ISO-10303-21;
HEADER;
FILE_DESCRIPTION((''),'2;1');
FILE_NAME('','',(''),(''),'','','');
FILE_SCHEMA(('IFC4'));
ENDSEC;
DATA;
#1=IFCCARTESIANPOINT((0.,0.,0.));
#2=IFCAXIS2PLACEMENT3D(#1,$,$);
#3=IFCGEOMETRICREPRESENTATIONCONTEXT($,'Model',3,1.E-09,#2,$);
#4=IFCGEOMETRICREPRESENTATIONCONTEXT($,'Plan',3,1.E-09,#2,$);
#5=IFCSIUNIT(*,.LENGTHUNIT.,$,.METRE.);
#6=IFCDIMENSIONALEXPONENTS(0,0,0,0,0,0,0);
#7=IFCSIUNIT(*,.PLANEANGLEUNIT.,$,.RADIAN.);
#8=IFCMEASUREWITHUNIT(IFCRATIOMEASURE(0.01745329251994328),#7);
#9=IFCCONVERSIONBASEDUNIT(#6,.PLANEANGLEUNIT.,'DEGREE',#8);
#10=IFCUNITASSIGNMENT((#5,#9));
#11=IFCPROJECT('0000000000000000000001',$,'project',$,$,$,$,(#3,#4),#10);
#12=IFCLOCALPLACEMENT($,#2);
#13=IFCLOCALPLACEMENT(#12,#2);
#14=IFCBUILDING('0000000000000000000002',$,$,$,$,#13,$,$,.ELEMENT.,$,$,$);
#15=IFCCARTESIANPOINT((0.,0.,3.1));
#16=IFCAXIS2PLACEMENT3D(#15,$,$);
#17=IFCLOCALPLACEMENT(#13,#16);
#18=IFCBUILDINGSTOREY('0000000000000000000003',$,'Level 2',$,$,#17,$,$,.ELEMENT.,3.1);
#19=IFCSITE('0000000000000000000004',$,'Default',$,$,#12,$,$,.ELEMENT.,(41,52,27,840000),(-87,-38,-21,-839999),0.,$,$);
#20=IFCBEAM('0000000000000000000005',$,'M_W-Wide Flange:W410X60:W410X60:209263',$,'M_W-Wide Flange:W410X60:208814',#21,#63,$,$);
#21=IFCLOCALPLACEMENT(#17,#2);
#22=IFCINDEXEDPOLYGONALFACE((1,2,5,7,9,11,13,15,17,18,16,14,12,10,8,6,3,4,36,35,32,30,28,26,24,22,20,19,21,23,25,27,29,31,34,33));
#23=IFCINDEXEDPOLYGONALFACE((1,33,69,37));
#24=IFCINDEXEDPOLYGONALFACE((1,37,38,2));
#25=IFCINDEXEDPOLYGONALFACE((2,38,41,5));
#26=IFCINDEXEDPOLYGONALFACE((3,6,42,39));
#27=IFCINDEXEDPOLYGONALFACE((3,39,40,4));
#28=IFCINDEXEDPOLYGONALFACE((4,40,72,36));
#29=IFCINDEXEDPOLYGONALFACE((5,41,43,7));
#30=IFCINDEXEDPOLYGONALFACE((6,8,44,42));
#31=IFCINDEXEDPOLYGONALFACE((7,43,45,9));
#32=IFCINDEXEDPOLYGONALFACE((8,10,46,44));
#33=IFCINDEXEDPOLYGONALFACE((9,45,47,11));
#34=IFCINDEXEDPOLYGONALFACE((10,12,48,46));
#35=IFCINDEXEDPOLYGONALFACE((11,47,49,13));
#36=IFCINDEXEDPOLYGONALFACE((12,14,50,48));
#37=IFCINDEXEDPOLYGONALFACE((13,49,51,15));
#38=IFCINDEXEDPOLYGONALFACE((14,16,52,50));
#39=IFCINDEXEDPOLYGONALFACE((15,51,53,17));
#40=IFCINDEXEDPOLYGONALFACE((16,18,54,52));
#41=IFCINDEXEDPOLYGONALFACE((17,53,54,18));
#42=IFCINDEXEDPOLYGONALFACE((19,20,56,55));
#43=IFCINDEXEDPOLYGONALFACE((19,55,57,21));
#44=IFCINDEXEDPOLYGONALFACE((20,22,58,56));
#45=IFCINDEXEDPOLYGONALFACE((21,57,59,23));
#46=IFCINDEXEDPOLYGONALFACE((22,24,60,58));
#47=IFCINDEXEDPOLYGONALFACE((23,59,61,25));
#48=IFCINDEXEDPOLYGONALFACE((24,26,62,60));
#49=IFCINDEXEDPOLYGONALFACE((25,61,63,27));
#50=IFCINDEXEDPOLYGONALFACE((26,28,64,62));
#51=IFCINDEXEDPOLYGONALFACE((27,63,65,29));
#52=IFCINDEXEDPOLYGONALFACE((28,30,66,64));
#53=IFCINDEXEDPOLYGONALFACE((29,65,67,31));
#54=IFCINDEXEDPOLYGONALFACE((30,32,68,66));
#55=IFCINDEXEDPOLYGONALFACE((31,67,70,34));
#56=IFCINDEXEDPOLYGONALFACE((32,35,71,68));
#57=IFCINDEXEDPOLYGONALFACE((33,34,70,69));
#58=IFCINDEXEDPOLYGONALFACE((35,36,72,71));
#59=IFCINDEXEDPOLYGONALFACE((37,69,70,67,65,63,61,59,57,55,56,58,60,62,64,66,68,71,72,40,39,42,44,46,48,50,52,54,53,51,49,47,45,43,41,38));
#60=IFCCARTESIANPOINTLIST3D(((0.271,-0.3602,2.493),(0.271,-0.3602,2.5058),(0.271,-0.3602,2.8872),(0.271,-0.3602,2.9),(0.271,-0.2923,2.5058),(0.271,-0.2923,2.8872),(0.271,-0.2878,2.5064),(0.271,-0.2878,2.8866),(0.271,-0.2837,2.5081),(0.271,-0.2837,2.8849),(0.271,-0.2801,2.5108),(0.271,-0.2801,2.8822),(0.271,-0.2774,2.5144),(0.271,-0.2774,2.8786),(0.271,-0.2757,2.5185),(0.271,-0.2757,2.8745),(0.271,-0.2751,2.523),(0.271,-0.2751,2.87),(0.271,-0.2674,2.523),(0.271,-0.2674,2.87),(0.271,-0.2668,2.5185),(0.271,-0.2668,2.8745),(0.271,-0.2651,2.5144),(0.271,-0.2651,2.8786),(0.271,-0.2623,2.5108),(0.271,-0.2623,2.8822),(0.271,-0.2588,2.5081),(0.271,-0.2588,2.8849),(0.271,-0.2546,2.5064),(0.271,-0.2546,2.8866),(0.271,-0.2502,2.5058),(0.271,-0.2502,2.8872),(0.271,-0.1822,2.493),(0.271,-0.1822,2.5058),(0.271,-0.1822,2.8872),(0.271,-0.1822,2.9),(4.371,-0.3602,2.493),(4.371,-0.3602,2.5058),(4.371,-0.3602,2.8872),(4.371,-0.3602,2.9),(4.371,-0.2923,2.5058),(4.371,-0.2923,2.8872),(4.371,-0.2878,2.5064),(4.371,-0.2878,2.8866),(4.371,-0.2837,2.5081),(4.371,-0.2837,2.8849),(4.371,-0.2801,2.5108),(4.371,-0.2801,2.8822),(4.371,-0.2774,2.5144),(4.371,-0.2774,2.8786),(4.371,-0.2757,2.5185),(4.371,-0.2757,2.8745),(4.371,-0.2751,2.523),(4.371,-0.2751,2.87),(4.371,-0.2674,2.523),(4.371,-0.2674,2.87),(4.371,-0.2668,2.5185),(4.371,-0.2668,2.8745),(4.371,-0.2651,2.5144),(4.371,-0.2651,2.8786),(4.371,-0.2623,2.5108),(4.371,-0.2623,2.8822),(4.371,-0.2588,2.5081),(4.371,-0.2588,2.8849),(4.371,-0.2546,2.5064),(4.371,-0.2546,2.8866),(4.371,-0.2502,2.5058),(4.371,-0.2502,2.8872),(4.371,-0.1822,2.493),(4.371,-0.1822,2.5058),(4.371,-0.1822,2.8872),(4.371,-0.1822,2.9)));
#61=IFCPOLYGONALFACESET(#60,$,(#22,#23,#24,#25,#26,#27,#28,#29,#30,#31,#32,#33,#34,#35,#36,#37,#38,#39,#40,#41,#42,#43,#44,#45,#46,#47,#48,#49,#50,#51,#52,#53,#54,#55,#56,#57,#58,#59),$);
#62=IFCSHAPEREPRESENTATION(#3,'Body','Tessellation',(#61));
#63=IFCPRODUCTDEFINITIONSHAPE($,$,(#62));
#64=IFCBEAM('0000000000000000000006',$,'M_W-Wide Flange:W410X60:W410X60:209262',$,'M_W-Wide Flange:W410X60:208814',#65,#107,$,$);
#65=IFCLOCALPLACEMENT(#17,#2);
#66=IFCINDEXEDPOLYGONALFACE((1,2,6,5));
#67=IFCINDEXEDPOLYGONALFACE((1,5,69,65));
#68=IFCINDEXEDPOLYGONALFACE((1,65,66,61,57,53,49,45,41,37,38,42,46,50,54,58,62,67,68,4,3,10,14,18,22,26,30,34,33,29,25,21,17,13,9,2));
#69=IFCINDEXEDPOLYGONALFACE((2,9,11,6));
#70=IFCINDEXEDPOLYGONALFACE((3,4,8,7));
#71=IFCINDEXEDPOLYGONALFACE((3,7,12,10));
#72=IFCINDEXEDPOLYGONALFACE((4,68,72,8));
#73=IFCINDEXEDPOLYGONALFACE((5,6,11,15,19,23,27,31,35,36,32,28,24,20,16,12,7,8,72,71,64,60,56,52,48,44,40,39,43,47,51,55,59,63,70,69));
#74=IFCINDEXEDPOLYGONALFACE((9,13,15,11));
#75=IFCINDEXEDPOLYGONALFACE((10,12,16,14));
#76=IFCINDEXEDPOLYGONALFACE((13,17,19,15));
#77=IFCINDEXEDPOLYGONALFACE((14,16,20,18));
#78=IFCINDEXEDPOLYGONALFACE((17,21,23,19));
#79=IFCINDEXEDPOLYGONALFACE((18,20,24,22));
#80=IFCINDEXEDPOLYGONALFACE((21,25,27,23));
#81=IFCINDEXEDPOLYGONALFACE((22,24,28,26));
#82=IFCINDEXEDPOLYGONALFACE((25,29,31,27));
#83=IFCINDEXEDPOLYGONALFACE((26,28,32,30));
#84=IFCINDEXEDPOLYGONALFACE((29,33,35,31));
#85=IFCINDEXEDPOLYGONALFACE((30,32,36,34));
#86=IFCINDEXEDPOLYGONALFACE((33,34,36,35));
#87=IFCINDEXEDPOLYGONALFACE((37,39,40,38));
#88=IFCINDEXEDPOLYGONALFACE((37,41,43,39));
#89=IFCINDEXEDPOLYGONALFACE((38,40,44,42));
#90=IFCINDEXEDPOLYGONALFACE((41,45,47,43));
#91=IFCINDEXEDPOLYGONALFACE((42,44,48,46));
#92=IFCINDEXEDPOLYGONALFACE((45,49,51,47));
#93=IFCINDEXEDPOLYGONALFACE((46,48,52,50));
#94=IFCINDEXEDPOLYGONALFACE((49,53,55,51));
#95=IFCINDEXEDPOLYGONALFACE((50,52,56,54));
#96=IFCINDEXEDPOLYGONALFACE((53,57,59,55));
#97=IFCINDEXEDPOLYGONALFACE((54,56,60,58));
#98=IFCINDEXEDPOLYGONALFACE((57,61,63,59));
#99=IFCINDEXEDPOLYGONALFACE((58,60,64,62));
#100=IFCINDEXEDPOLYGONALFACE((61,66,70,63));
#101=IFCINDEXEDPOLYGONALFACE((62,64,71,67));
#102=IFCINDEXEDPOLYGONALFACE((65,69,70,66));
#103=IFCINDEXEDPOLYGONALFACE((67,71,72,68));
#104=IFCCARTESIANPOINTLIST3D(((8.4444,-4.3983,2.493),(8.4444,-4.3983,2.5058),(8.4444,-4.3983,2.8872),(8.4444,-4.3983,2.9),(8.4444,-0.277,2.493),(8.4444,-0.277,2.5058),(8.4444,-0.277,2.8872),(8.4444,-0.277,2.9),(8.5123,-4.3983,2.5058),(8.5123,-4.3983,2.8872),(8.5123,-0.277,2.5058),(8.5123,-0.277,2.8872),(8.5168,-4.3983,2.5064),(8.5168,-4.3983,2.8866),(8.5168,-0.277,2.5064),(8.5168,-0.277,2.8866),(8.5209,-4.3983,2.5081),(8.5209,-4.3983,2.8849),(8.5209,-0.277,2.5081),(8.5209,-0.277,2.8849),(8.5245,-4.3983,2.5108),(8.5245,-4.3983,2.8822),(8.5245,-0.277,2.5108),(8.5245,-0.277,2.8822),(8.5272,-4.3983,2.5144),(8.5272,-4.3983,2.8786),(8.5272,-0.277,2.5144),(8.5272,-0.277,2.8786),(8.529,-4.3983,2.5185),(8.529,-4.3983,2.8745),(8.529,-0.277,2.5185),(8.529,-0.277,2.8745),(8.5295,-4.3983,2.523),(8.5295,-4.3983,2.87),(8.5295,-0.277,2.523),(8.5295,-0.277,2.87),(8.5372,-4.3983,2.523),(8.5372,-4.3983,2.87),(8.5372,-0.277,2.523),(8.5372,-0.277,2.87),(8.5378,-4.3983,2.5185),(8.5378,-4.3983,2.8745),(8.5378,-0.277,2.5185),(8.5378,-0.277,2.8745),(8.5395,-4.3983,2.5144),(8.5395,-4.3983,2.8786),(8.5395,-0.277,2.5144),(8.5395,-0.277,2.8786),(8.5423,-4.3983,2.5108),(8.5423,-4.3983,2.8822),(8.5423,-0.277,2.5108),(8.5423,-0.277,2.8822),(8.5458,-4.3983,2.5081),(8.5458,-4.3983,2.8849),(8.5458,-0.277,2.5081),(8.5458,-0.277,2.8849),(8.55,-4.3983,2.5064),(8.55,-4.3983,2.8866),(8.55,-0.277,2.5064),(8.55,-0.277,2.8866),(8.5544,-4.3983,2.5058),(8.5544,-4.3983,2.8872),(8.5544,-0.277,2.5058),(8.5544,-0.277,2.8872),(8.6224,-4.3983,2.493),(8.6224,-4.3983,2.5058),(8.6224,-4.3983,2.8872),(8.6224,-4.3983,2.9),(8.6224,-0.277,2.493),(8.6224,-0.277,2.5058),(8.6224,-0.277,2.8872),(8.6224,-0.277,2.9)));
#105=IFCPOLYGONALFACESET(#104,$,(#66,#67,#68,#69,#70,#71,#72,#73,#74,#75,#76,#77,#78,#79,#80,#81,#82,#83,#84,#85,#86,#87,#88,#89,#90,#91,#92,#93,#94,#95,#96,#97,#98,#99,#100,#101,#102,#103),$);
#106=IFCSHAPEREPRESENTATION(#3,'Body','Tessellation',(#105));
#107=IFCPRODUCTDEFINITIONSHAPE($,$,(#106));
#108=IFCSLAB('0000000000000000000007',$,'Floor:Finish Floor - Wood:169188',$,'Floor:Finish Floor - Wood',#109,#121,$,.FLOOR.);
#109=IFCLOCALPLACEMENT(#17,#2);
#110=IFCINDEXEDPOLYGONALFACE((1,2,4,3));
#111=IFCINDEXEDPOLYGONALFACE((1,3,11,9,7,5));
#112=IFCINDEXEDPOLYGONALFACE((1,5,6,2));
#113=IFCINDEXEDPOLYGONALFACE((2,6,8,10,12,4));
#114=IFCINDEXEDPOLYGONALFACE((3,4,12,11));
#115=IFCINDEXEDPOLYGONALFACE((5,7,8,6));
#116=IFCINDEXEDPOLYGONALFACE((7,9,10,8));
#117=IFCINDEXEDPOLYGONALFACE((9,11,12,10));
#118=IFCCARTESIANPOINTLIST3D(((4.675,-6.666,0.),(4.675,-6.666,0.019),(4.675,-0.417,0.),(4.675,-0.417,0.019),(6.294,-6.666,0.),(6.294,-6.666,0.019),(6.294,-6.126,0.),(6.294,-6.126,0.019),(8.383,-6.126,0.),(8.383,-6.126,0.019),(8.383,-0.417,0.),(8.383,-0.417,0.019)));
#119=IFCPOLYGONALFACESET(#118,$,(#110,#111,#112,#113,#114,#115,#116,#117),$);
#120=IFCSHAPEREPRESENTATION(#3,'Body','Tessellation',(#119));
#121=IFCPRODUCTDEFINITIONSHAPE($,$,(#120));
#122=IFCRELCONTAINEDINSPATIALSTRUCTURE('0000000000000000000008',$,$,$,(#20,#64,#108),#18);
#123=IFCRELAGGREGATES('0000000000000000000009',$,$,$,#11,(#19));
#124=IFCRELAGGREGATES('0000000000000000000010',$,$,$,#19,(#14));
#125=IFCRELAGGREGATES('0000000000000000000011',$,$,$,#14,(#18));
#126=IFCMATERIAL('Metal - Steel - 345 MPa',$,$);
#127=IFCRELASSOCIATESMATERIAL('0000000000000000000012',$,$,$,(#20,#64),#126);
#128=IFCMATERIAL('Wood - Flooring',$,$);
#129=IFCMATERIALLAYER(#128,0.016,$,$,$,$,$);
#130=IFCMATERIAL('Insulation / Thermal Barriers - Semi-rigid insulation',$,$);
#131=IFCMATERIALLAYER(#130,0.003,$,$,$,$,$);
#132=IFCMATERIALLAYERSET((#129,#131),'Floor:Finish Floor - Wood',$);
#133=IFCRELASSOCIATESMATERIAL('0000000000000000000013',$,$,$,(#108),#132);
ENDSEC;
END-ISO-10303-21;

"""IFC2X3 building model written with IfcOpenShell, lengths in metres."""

from ifc_helpers import new_model, entity, si_unit, converted_unit, frame, frame_2d, origin, place, context, project, spatial, polyline, circle_curve, parameter, trimmed, segment, composite_curve, outline, extrude, material, layer, layer_set, layer_usage, element, save


model = new_model("IFC2X3")

# Units and contexts
model_context = context("Model", 3, precision=1e-09, world=origin())
plan_context = context("Plan", 3, precision=1e-09, world=origin())
ifc_project = project(units=[si_unit("LENGTHUNIT", "METRE"), converted_unit("PLANEANGLEUNIT", "DEGREE", entity("IfcRatioMeasure", 0.01745329251994328), si_unit("PLANEANGLEUNIT", "RADIAN"), dimensions=[0, 0, 0, 0, 0, 0, 0])], contexts=[model_context, plan_context])

# Site, building, storey
site_placement = place(None, origin())
site = spatial("IfcSite", under=ifc_project, at=site_placement, Name="Default", CompositionType="ELEMENT", RefLatitude=(41, 52, 27, 840000), RefLongitude=(-87, -38, -21, -839999), RefElevation=0.0)
building_placement = place(site_placement, origin())
building = spatial("IfcBuilding", under=site, at=building_placement, CompositionType="ELEMENT")
storey_placement = place(building_placement, frame((0.0, 0.0, 3.1)))
storey = spatial("IfcBuildingStorey", under=building, at=storey_placement, Name="Level 2", CompositionType="ELEMENT", Elevation=3.1)

# Beams
ifc_material_1 = material(Name="Metal - Steel - 345 MPa")
beam_1_placement = place(storey_placement, frame((4.371, -0.2712, 2.9), z_axis=(0.0, 0.0, 1.0), x_axis=(0.0, 1.0, 0.0)))
element("IfcBeam", 1, at=beam_1_placement, inside=storey, material=ifc_material_1, Name="M_W-Wide Flange:W410X60:W410X60:209263", ObjectType="M_W-Wide Flange:W410X60:208814", context=model_context, shape_type="SweptSolid", body=[
    extrude(outline(composite_curve([segment(polyline([(0.1907, -0.089), (0.2035, -0.089)]), True, "CONTINUOUS"), segment(polyline([(0.2035, -0.089), (0.2035, 0.089)]), True, "CONTINUOUS"), segment(polyline([(0.2035, 0.089), (0.1907, 0.089)]), True, "CONTINUOUS"), segment(polyline([(0.1907, 0.089), (0.1907, 0.0211)]), True, "CONTINUOUS"), segment(trimmed(circle_curve(frame_2d((0.1735, 0.0211), x_axis=(1.0, 0.0)), 0.0172), [parameter(270.0)], [parameter(360.0)], True, "PARAMETER"), False, "CONTINUOUS"), segment(polyline([(0.1735, 0.0039), (-0.1735, 0.0039)]), True, "CONTINUOUS"), segment(trimmed(circle_curve(frame_2d((-0.1735, 0.0211), x_axis=(0.0, -1.0)), 0.0172), [parameter(270.0)], [parameter(360.0)], True, "PARAMETER"), False, "CONTINUOUS"), segment(polyline([(-0.1907, 0.0211), (-0.1907, 0.089)]), True, "CONTINUOUS"), segment(polyline([(-0.1907, 0.089), (-0.2035, 0.089)]), True, "CONTINUOUS"), segment(polyline([(-0.2035, 0.089), (-0.2035, -0.089)]), True, "CONTINUOUS"), segment(polyline([(-0.2035, -0.089), (-0.1907, -0.089)]), True, "CONTINUOUS"), segment(polyline([(-0.1907, -0.089), (-0.1907, -0.0211)]), True, "CONTINUOUS"), segment(trimmed(circle_curve(frame_2d((-0.1735, -0.0211), x_axis=(-1.0, 0.0)), 0.0172), [parameter(270.0)], [parameter(0.0)], True, "PARAMETER"), False, "CONTINUOUS"), segment(polyline([(-0.1735, -0.0039), (0.1735, -0.0039)]), True, "CONTINUOUS"), segment(trimmed(circle_curve(frame_2d((0.1735, -0.0211), x_axis=(0.0, 1.0)), 0.0172), [parameter(270.0)], [parameter(0.0)], True, "PARAMETER"), False, "CONTINUOUS"), segment(polyline([(0.1907, -0.0211), (0.1907, -0.089)]), True, "CONTINUOUS")], self_intersect=False)), frame((0.0, 4.1, -0.2035), z_axis=(0.0, -1.0, 0.0), x_axis=(0.0, 0.0, -1.0)), (0.0, 0.0, 1.0), 4.1),
])
beam_2_placement = place(storey_placement, frame((8.5334, -4.3983, 2.9)))
element("IfcBeam", 2, at=beam_2_placement, inside=storey, material=ifc_material_1, Name="M_W-Wide Flange:W410X60:W410X60:209262", ObjectType="M_W-Wide Flange:W410X60:208814", context=model_context, shape_type="SweptSolid", body=[
    extrude(outline(composite_curve([segment(polyline([(-0.089, -0.1907), (-0.089, -0.2035)]), True, "CONTINUOUS"), segment(polyline([(-0.089, -0.2035), (0.089, -0.2035)]), True, "CONTINUOUS"), segment(polyline([(0.089, -0.2035), (0.089, -0.1907)]), True, "CONTINUOUS"), segment(polyline([(0.089, -0.1907), (0.021, -0.1907)]), True, "CONTINUOUS"), segment(trimmed(circle_curve(frame_2d((0.021, -0.1735), x_axis=(0.0, -1.0)), 0.0172), [parameter(270.0)], [parameter(360.0)], True, "PARAMETER"), False, "CONTINUOUS"), segment(polyline([(0.0038, -0.1735), (0.0038, 0.1735)]), True, "CONTINUOUS"), segment(trimmed(circle_curve(frame_2d((0.021, 0.1735), x_axis=(-1.0, 0.0)), 0.0172), [parameter(270.0)], [parameter(360.0)], True, "PARAMETER"), False, "CONTINUOUS"), segment(polyline([(0.021, 0.1907), (0.089, 0.1907)]), True, "CONTINUOUS"), segment(polyline([(0.089, 0.1907), (0.089, 0.2035)]), True, "CONTINUOUS"), segment(polyline([(0.089, 0.2035), (-0.089, 0.2035)]), True, "CONTINUOUS"), segment(polyline([(-0.089, 0.2035), (-0.089, 0.1907)]), True, "CONTINUOUS"), segment(polyline([(-0.089, 0.1907), (-0.0211, 0.1907)]), True, "CONTINUOUS"), segment(trimmed(circle_curve(frame_2d((-0.0211, 0.1735), x_axis=(0.0, 1.0)), 0.0172), [parameter(270.0)], [parameter(0.0)], True, "PARAMETER"), False, "CONTINUOUS"), segment(polyline([(-0.0039, 0.1735), (-0.0039, -0.1735)]), True, "CONTINUOUS"), segment(trimmed(circle_curve(frame_2d((-0.0211, -0.1735), x_axis=(1.0, 0.0)), 0.0172), [parameter(270.0)], [parameter(0.0)], True, "PARAMETER"), False, "CONTINUOUS"), segment(polyline([(-0.0211, -0.1907), (-0.089, -0.1907)]), True, "CONTINUOUS")], self_intersect=False)), frame((0.0, 0.0, -0.2035), z_axis=(0.0, -1.0, 0.0), x_axis=(1.0, 0.0, 0.0)), (0.0, 0.0, -1.0), 4.1213),
])

# Slab
ifc_material_2 = material(Name="Wood - Flooring")
ifc_layer_1 = layer(ifc_material_2, 0.016)
ifc_material_3 = material(Name="Insulation / Thermal Barriers - Semi-rigid insulation")
ifc_layer_2 = layer(ifc_material_3, 0.003)
ifc_layer_set_1 = layer_set([ifc_layer_1, ifc_layer_2], Name="Floor:Finish Floor - Wood")
ifc_layer_usage_1 = layer_usage(ifc_layer_set_1, "AXIS3", "POSITIVE", 0.0)
slab_placement = place(storey_placement, frame((4.675, -6.666, 0.0)))
element("IfcSlab", 3, at=slab_placement, inside=storey, material=ifc_layer_usage_1, Name="Floor:Finish Floor - Wood:169188", ObjectType="Floor:Finish Floor - Wood", PredefinedType="FLOOR", context=model_context, shape_type="SweptSolid", body=[
    extrude(outline(polyline([(-1.854, 3.1245), (-1.854, -2.5845), (0.235, -2.5845), (0.235, -3.1245), (1.854, -3.1245), (1.854, 3.1245), (-1.854, 3.1245)])), frame((1.854, 3.1245, 0.019), z_axis=(0.0, 0.0, -1.0), x_axis=(-1.0, 0.0, 0.0)), (0.0, 0.0, 1.0), 0.019),
])

save(model, "model.ifc")
